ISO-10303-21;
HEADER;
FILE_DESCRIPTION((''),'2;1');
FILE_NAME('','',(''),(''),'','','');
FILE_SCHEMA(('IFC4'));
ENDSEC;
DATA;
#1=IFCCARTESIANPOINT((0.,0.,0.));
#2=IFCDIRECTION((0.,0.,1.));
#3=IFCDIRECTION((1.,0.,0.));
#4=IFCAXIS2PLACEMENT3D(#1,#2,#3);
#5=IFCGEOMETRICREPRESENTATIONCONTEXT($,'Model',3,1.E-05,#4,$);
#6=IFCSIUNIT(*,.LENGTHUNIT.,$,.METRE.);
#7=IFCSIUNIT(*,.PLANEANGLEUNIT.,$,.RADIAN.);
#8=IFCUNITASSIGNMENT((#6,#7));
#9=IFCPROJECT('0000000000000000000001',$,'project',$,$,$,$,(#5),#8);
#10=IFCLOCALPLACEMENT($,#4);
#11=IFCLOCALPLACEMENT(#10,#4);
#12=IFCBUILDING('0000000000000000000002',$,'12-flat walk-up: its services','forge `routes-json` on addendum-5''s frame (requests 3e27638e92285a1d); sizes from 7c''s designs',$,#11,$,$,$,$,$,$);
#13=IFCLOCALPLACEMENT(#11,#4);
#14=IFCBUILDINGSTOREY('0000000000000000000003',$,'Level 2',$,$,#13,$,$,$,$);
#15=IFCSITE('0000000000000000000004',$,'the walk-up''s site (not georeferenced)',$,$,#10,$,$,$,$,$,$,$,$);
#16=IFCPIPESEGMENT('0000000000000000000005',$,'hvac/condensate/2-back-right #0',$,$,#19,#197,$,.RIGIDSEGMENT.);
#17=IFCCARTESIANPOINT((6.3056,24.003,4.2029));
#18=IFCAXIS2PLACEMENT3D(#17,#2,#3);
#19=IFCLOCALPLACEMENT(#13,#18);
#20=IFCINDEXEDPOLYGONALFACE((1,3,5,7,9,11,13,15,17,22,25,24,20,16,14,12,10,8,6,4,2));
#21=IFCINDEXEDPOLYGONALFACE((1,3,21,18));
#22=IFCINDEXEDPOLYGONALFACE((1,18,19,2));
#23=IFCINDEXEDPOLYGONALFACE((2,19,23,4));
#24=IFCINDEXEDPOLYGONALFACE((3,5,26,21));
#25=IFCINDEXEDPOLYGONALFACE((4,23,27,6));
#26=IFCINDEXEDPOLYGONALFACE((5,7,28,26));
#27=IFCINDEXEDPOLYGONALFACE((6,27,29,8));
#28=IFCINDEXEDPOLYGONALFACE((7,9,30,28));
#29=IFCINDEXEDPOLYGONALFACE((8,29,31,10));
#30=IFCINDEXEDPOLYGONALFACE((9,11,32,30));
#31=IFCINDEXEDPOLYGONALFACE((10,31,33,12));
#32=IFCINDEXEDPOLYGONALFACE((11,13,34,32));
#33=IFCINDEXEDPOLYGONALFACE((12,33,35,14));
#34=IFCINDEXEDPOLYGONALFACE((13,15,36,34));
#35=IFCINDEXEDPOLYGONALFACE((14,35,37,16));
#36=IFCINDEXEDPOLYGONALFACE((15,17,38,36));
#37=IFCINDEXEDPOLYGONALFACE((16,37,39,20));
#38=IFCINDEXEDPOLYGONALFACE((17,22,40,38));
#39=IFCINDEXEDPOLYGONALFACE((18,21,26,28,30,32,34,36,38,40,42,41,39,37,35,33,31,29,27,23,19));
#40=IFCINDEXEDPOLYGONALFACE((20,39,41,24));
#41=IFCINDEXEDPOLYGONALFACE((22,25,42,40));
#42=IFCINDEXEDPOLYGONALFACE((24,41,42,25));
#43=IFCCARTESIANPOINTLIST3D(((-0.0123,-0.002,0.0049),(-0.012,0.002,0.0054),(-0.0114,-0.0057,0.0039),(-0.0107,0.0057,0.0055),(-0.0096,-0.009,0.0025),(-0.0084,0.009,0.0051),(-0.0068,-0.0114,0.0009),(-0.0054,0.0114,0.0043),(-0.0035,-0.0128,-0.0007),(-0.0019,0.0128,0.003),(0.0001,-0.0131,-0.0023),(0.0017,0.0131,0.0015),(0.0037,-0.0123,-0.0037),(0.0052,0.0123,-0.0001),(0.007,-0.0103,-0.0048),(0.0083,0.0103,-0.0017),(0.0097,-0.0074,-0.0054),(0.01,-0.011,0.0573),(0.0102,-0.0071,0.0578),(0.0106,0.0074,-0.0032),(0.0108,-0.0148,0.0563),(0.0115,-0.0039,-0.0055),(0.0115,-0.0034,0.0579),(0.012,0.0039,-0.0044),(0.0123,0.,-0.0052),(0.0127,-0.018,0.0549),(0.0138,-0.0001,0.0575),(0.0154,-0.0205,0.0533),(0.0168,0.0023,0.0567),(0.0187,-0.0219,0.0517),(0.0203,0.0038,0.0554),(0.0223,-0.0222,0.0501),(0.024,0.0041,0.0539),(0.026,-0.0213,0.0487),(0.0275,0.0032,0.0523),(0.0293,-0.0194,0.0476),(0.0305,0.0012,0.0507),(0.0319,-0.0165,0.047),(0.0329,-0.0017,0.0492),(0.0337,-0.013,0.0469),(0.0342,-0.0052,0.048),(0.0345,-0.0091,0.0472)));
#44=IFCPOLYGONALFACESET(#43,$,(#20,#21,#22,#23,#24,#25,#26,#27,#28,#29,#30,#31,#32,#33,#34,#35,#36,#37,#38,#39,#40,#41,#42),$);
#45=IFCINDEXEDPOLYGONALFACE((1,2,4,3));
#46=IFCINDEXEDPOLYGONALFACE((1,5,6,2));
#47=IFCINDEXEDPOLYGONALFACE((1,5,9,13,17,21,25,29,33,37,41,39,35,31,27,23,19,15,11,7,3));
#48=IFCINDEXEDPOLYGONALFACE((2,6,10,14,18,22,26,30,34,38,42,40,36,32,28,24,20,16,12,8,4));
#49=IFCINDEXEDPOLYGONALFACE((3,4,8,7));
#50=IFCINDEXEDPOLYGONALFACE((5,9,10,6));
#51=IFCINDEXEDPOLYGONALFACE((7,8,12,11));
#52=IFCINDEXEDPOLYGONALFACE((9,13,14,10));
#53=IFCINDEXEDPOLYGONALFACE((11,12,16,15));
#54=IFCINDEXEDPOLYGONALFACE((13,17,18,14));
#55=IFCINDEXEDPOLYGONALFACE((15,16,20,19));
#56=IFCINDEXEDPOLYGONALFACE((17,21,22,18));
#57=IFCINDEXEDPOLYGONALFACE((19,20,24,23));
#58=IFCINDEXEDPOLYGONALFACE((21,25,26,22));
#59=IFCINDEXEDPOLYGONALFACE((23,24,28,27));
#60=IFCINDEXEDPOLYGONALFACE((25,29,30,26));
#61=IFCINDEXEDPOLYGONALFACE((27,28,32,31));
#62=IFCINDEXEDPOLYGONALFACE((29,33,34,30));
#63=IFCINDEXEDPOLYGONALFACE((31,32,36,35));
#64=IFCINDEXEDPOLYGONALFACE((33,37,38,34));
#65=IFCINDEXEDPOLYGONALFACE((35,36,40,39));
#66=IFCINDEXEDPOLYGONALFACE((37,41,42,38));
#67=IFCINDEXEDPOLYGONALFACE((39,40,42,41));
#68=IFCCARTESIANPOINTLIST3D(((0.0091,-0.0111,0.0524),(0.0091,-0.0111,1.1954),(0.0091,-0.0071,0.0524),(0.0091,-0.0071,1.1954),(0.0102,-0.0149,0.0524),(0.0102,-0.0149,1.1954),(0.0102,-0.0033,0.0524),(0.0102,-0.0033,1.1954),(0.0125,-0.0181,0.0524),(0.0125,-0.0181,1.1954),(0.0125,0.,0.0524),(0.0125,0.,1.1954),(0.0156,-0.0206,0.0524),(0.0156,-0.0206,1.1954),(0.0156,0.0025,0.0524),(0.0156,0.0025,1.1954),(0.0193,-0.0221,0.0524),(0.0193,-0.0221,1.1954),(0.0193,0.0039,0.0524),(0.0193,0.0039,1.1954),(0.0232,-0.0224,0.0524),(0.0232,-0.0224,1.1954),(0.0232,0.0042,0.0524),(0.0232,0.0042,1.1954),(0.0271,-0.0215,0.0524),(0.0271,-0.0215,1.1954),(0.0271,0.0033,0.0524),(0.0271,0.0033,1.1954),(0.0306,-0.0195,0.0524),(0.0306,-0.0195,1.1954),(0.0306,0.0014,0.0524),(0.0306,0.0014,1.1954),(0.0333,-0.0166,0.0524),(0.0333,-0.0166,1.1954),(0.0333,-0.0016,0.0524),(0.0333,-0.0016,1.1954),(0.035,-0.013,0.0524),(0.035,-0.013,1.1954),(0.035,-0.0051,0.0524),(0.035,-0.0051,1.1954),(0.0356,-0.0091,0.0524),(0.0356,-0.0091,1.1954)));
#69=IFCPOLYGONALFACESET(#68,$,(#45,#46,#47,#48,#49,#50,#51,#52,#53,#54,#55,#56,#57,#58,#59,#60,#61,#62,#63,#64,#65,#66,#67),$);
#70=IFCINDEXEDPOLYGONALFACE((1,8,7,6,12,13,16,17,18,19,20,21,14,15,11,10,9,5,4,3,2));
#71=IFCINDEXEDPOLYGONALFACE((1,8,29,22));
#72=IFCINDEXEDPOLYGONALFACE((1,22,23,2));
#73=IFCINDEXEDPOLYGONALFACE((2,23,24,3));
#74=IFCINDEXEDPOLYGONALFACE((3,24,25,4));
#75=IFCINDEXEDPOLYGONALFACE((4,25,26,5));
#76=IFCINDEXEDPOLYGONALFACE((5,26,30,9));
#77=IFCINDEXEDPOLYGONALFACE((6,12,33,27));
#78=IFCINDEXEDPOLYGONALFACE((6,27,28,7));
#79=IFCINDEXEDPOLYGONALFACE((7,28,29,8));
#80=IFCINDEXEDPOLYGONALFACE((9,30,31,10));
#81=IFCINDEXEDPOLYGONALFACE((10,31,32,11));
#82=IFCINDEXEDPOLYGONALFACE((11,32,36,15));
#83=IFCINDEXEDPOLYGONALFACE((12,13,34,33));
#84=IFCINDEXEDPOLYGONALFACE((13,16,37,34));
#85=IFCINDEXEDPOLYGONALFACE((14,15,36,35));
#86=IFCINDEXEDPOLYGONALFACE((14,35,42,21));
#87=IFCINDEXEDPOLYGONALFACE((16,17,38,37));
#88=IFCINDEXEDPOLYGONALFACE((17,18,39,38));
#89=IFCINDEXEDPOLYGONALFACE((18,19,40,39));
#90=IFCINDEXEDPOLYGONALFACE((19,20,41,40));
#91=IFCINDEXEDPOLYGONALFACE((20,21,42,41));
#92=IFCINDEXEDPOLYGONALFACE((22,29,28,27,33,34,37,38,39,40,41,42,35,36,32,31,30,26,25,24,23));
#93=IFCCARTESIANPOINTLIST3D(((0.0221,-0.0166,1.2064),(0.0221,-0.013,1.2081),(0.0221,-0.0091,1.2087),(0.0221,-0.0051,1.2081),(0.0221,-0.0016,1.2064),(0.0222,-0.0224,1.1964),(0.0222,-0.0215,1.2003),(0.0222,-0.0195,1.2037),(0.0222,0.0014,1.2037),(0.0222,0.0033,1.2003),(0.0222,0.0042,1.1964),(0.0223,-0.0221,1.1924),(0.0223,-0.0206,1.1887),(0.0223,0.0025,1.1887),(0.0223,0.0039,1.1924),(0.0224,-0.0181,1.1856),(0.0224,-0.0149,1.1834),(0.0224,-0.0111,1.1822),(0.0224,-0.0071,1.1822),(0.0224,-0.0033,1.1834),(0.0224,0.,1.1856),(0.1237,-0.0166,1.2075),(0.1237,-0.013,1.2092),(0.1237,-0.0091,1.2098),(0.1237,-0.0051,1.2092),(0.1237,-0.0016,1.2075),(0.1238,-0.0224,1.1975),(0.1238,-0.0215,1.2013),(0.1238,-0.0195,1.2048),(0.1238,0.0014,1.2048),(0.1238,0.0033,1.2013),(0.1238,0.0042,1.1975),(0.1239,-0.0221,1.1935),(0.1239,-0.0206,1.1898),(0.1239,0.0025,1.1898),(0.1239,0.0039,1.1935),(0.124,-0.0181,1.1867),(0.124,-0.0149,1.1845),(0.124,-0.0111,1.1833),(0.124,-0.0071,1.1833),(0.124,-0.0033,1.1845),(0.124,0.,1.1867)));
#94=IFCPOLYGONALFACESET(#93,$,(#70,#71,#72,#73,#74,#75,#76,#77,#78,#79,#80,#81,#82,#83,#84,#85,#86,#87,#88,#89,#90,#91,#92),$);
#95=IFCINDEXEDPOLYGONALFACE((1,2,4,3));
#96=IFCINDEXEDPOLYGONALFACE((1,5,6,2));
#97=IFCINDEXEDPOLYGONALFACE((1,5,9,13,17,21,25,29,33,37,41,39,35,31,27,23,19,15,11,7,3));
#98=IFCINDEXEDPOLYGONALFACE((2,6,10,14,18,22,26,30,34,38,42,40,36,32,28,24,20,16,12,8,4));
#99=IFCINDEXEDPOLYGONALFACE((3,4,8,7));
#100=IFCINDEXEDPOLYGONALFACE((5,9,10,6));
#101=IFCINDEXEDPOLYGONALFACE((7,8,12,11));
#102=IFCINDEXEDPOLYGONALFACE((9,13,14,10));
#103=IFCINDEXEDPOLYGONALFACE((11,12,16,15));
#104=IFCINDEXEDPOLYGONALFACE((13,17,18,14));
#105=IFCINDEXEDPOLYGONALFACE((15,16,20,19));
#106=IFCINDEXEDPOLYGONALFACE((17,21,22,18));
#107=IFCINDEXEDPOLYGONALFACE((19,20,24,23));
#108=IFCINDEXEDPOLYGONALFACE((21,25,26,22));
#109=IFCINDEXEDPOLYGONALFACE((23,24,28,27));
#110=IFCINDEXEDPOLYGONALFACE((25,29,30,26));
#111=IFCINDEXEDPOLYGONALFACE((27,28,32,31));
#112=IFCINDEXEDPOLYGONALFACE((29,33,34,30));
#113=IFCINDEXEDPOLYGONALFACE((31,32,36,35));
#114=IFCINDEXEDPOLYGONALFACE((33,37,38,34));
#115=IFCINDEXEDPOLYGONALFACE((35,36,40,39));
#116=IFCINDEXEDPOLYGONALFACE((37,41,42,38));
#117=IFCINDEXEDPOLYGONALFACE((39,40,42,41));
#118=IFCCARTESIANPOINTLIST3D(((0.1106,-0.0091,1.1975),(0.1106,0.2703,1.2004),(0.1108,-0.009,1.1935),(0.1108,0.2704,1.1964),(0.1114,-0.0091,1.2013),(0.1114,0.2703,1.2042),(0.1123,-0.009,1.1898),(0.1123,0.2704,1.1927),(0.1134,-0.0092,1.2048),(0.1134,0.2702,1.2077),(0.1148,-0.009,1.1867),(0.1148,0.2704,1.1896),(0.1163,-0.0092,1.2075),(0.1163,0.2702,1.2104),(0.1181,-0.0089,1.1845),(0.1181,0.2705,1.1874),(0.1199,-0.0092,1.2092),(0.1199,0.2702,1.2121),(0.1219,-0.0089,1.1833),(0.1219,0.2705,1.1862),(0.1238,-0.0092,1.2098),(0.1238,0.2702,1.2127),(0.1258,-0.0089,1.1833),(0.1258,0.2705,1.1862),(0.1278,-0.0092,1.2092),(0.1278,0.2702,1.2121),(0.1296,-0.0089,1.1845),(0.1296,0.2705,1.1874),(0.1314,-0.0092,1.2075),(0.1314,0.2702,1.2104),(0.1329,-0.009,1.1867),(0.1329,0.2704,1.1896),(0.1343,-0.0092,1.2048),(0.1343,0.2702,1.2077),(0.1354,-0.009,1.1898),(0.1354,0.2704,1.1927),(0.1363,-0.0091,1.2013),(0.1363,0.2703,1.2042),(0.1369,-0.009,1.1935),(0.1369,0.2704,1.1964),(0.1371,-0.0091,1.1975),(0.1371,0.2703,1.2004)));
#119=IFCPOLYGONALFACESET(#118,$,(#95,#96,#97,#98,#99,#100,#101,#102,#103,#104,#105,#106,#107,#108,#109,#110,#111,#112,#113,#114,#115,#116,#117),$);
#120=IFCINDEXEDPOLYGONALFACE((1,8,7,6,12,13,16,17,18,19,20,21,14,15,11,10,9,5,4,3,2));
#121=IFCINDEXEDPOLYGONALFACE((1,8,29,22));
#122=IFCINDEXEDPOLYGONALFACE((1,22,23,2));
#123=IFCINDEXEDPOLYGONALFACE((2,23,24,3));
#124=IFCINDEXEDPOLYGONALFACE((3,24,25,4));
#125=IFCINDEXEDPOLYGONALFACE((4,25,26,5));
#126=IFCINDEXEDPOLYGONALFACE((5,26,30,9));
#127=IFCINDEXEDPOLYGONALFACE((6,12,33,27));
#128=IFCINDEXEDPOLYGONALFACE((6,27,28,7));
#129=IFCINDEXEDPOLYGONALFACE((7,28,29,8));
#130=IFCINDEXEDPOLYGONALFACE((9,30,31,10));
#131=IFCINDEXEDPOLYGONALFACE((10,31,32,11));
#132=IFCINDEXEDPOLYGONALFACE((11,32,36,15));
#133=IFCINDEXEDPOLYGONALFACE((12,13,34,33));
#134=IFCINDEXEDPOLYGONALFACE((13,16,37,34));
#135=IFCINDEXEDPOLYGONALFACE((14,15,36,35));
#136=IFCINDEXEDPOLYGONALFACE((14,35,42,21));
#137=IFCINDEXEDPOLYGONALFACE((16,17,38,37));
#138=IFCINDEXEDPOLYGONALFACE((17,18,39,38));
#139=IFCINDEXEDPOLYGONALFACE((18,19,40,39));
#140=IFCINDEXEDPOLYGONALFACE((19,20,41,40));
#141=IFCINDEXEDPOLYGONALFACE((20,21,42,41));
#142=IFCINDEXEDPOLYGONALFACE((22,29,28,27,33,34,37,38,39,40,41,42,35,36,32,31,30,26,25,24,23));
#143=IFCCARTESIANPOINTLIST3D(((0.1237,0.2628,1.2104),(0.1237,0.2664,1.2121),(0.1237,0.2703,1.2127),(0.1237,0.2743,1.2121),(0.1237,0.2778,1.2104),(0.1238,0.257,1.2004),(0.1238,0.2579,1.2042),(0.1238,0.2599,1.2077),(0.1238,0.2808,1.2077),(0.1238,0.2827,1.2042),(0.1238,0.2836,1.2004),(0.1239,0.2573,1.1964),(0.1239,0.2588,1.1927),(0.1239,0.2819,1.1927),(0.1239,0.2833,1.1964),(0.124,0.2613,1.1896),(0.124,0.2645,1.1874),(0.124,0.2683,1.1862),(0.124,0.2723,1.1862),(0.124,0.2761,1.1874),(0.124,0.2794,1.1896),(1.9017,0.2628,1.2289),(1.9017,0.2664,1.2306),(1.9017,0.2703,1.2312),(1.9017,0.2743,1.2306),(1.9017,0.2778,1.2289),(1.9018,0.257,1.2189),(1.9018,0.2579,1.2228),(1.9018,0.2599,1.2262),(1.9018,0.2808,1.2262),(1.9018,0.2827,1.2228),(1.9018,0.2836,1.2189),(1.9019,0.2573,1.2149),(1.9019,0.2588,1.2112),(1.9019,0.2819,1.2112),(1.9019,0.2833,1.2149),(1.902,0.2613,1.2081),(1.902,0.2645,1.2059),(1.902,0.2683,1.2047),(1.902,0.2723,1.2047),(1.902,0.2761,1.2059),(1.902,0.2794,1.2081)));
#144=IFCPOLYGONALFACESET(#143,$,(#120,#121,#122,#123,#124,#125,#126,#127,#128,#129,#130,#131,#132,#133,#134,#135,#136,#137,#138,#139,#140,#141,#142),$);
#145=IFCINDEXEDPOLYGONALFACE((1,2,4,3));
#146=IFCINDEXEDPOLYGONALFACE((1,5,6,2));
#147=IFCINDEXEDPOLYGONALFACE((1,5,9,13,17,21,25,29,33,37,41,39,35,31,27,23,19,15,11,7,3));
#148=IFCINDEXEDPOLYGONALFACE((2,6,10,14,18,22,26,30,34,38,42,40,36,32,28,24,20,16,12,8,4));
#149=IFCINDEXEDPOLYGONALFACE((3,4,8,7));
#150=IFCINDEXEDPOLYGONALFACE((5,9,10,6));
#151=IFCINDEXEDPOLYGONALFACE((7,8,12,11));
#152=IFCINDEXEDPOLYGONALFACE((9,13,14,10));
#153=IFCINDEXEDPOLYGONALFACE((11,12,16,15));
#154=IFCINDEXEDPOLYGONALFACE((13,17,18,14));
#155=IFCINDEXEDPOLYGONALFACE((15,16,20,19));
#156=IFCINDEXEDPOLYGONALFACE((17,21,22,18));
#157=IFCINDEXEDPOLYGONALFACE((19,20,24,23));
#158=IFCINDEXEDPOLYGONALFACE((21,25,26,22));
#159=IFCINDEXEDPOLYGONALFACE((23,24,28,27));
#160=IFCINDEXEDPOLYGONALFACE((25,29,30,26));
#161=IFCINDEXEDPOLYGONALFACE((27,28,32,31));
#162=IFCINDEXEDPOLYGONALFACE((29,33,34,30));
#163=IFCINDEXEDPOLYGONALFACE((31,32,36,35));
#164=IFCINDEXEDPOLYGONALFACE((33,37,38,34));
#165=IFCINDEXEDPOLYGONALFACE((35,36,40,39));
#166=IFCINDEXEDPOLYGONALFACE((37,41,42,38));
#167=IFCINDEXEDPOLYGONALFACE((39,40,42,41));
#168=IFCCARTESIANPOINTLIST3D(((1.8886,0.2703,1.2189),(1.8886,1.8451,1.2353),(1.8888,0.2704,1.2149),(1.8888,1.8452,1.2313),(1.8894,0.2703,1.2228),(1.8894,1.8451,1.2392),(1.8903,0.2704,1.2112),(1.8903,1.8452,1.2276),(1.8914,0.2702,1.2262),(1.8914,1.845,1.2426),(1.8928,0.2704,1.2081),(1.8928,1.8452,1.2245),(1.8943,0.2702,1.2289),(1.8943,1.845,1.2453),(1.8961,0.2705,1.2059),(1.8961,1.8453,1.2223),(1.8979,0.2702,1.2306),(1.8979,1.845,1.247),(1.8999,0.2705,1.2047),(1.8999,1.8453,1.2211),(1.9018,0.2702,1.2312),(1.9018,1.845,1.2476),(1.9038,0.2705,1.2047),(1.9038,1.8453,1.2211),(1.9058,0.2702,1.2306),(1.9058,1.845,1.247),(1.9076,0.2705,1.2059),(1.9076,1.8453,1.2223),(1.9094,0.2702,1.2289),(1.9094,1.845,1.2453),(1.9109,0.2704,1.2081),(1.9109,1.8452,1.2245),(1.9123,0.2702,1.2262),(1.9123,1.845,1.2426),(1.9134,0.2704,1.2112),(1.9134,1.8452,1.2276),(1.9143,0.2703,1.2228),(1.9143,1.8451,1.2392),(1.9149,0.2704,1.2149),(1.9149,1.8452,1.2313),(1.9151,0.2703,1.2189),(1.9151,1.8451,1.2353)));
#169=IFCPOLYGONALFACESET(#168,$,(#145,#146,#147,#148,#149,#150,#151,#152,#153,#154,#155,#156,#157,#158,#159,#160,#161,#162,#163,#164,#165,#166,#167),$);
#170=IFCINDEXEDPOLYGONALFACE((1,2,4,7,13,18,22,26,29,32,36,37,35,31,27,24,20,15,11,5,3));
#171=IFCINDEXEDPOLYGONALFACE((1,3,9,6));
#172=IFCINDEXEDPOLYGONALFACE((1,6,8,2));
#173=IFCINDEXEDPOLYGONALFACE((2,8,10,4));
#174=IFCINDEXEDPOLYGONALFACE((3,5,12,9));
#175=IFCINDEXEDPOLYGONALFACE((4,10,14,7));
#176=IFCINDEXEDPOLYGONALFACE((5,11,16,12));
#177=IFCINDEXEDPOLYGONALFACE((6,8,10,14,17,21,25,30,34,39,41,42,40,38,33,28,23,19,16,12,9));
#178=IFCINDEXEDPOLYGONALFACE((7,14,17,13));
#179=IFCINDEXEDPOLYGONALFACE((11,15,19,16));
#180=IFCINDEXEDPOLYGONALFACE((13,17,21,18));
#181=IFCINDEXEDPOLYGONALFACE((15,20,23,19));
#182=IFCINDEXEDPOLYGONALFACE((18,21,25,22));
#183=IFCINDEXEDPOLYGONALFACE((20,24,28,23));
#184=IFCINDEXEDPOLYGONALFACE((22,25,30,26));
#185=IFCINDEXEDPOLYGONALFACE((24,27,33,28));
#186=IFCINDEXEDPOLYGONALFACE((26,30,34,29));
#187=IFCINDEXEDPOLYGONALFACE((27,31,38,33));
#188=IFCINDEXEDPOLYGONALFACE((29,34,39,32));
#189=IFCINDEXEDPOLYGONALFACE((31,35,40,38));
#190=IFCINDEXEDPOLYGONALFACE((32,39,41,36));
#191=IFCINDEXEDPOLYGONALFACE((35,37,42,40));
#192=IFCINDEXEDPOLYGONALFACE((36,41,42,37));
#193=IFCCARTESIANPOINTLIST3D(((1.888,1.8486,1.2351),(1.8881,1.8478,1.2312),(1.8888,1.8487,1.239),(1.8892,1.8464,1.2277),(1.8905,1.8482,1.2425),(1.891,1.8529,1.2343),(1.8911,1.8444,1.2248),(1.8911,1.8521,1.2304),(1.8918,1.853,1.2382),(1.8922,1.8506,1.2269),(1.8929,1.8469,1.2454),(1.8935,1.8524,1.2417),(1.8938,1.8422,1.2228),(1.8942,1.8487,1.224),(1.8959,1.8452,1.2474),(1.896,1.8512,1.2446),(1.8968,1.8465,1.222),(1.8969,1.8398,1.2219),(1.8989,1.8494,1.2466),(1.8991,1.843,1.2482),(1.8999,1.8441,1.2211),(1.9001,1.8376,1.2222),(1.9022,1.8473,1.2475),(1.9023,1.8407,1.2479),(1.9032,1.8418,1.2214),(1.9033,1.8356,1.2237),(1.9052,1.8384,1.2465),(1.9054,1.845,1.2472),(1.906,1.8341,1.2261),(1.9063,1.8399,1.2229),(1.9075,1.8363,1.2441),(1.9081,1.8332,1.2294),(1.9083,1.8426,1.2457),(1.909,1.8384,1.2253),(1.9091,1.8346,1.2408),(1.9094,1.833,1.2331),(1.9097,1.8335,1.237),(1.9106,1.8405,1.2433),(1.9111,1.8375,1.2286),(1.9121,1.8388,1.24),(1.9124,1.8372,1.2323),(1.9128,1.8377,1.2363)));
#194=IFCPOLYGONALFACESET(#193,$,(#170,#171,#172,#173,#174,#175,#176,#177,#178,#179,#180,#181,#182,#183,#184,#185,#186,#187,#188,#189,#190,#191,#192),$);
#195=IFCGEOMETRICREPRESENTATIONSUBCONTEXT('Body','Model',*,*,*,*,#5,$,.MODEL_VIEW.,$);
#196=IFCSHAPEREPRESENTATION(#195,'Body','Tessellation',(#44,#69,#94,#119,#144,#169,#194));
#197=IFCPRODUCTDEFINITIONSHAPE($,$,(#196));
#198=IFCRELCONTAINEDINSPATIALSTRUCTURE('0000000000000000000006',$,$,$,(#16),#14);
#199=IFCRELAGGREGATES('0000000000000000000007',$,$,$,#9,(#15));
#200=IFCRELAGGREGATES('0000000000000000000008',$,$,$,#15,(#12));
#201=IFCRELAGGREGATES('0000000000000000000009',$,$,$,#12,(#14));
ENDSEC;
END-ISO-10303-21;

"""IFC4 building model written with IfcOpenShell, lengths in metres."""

from ifc_helpers import new_model, entity, si_unit, frame, origin_with_axes, place, context, subcontext, project, spatial, element, save


model = new_model("IFC4")

# Units and contexts
model_context = context("Model", 3, precision=1e-05, world=origin_with_axes())
body_context = subcontext(model_context, "Body", "Model", "MODEL_VIEW")
ifc_project = project(units=[si_unit("LENGTHUNIT", "METRE"), si_unit("PLANEANGLEUNIT", "RADIAN")], contexts=[model_context])

# Site, building, storey
site_placement = place(None, origin_with_axes())
site = spatial("IfcSite", under=ifc_project, at=site_placement, Name="the walk-up's site (not georeferenced)")
building_placement = place(site_placement, origin_with_axes())
building = spatial("IfcBuilding", under=site, at=building_placement, Name="12-flat walk-up: its services", Description="forge `routes-json` on addendum-5's frame (requests 3e27638e92285a1d); sizes from 7c's designs")
storey_placement = place(building_placement, origin_with_axes())
storey = spatial("IfcBuildingStorey", under=building, at=storey_placement, Name="Level 2")

# Pipe segment
pipe_segment_1_placement = place(storey_placement, frame((6.3056, 24.003, 4.2029), z_axis=(0.0, 0.0, 1.0), x_axis=(1.0, 0.0, 0.0)))
element("IfcPipeSegment", 1, at=pipe_segment_1_placement, inside=storey, Name="hvac/condensate/2-back-right #0", PredefinedType="RIGIDSEGMENT", context=body_context, shape_type="AdvancedSweptSolid", body=[
    entity("IfcSweptDiskSolid", entity("IfcPolyline", [entity("IfcCartesianPoint", [0.0, 0.0, 0.0]), entity("IfcCartesianPoint", [0.0222, -0.0091, 0.0524])]), 0.0133),
    entity("IfcSweptDiskSolid", entity("IfcPolyline", [entity("IfcCartesianPoint", [0.0222, -0.0091, 0.0524]), entity("IfcCartesianPoint", [0.0222, -0.0091, 1.1954])]), 0.0133),
    entity("IfcSweptDiskSolid", entity("IfcPolyline", [entity("IfcCartesianPoint", [0.0222, -0.0091, 1.1954]), entity("IfcCartesianPoint", [0.1238, -0.0091, 1.1965])]), 0.0133),
    entity("IfcSweptDiskSolid", entity("IfcPolyline", [entity("IfcCartesianPoint", [0.1238, -0.0091, 1.1965]), entity("IfcCartesianPoint", [0.1238, 0.2703, 1.1994])]), 0.0133),
    entity("IfcSweptDiskSolid", entity("IfcPolyline", [entity("IfcCartesianPoint", [0.1238, 0.2703, 1.1994]), entity("IfcCartesianPoint", [1.9018, 0.2703, 1.2179])]), 0.0133),
    entity("IfcSweptDiskSolid", entity("IfcPolyline", [entity("IfcCartesianPoint", [1.9018, 0.2703, 1.2179]), entity("IfcCartesianPoint", [1.9018, 1.8451, 1.2343])]), 0.0133),
    entity("IfcSweptDiskSolid", entity("IfcPolyline", [entity("IfcCartesianPoint", [1.9018, 1.8451, 1.2343]), entity("IfcCartesianPoint", [1.8988, 1.8409, 1.2351])]), 0.0133),
])

save(model, "model.ifc")
